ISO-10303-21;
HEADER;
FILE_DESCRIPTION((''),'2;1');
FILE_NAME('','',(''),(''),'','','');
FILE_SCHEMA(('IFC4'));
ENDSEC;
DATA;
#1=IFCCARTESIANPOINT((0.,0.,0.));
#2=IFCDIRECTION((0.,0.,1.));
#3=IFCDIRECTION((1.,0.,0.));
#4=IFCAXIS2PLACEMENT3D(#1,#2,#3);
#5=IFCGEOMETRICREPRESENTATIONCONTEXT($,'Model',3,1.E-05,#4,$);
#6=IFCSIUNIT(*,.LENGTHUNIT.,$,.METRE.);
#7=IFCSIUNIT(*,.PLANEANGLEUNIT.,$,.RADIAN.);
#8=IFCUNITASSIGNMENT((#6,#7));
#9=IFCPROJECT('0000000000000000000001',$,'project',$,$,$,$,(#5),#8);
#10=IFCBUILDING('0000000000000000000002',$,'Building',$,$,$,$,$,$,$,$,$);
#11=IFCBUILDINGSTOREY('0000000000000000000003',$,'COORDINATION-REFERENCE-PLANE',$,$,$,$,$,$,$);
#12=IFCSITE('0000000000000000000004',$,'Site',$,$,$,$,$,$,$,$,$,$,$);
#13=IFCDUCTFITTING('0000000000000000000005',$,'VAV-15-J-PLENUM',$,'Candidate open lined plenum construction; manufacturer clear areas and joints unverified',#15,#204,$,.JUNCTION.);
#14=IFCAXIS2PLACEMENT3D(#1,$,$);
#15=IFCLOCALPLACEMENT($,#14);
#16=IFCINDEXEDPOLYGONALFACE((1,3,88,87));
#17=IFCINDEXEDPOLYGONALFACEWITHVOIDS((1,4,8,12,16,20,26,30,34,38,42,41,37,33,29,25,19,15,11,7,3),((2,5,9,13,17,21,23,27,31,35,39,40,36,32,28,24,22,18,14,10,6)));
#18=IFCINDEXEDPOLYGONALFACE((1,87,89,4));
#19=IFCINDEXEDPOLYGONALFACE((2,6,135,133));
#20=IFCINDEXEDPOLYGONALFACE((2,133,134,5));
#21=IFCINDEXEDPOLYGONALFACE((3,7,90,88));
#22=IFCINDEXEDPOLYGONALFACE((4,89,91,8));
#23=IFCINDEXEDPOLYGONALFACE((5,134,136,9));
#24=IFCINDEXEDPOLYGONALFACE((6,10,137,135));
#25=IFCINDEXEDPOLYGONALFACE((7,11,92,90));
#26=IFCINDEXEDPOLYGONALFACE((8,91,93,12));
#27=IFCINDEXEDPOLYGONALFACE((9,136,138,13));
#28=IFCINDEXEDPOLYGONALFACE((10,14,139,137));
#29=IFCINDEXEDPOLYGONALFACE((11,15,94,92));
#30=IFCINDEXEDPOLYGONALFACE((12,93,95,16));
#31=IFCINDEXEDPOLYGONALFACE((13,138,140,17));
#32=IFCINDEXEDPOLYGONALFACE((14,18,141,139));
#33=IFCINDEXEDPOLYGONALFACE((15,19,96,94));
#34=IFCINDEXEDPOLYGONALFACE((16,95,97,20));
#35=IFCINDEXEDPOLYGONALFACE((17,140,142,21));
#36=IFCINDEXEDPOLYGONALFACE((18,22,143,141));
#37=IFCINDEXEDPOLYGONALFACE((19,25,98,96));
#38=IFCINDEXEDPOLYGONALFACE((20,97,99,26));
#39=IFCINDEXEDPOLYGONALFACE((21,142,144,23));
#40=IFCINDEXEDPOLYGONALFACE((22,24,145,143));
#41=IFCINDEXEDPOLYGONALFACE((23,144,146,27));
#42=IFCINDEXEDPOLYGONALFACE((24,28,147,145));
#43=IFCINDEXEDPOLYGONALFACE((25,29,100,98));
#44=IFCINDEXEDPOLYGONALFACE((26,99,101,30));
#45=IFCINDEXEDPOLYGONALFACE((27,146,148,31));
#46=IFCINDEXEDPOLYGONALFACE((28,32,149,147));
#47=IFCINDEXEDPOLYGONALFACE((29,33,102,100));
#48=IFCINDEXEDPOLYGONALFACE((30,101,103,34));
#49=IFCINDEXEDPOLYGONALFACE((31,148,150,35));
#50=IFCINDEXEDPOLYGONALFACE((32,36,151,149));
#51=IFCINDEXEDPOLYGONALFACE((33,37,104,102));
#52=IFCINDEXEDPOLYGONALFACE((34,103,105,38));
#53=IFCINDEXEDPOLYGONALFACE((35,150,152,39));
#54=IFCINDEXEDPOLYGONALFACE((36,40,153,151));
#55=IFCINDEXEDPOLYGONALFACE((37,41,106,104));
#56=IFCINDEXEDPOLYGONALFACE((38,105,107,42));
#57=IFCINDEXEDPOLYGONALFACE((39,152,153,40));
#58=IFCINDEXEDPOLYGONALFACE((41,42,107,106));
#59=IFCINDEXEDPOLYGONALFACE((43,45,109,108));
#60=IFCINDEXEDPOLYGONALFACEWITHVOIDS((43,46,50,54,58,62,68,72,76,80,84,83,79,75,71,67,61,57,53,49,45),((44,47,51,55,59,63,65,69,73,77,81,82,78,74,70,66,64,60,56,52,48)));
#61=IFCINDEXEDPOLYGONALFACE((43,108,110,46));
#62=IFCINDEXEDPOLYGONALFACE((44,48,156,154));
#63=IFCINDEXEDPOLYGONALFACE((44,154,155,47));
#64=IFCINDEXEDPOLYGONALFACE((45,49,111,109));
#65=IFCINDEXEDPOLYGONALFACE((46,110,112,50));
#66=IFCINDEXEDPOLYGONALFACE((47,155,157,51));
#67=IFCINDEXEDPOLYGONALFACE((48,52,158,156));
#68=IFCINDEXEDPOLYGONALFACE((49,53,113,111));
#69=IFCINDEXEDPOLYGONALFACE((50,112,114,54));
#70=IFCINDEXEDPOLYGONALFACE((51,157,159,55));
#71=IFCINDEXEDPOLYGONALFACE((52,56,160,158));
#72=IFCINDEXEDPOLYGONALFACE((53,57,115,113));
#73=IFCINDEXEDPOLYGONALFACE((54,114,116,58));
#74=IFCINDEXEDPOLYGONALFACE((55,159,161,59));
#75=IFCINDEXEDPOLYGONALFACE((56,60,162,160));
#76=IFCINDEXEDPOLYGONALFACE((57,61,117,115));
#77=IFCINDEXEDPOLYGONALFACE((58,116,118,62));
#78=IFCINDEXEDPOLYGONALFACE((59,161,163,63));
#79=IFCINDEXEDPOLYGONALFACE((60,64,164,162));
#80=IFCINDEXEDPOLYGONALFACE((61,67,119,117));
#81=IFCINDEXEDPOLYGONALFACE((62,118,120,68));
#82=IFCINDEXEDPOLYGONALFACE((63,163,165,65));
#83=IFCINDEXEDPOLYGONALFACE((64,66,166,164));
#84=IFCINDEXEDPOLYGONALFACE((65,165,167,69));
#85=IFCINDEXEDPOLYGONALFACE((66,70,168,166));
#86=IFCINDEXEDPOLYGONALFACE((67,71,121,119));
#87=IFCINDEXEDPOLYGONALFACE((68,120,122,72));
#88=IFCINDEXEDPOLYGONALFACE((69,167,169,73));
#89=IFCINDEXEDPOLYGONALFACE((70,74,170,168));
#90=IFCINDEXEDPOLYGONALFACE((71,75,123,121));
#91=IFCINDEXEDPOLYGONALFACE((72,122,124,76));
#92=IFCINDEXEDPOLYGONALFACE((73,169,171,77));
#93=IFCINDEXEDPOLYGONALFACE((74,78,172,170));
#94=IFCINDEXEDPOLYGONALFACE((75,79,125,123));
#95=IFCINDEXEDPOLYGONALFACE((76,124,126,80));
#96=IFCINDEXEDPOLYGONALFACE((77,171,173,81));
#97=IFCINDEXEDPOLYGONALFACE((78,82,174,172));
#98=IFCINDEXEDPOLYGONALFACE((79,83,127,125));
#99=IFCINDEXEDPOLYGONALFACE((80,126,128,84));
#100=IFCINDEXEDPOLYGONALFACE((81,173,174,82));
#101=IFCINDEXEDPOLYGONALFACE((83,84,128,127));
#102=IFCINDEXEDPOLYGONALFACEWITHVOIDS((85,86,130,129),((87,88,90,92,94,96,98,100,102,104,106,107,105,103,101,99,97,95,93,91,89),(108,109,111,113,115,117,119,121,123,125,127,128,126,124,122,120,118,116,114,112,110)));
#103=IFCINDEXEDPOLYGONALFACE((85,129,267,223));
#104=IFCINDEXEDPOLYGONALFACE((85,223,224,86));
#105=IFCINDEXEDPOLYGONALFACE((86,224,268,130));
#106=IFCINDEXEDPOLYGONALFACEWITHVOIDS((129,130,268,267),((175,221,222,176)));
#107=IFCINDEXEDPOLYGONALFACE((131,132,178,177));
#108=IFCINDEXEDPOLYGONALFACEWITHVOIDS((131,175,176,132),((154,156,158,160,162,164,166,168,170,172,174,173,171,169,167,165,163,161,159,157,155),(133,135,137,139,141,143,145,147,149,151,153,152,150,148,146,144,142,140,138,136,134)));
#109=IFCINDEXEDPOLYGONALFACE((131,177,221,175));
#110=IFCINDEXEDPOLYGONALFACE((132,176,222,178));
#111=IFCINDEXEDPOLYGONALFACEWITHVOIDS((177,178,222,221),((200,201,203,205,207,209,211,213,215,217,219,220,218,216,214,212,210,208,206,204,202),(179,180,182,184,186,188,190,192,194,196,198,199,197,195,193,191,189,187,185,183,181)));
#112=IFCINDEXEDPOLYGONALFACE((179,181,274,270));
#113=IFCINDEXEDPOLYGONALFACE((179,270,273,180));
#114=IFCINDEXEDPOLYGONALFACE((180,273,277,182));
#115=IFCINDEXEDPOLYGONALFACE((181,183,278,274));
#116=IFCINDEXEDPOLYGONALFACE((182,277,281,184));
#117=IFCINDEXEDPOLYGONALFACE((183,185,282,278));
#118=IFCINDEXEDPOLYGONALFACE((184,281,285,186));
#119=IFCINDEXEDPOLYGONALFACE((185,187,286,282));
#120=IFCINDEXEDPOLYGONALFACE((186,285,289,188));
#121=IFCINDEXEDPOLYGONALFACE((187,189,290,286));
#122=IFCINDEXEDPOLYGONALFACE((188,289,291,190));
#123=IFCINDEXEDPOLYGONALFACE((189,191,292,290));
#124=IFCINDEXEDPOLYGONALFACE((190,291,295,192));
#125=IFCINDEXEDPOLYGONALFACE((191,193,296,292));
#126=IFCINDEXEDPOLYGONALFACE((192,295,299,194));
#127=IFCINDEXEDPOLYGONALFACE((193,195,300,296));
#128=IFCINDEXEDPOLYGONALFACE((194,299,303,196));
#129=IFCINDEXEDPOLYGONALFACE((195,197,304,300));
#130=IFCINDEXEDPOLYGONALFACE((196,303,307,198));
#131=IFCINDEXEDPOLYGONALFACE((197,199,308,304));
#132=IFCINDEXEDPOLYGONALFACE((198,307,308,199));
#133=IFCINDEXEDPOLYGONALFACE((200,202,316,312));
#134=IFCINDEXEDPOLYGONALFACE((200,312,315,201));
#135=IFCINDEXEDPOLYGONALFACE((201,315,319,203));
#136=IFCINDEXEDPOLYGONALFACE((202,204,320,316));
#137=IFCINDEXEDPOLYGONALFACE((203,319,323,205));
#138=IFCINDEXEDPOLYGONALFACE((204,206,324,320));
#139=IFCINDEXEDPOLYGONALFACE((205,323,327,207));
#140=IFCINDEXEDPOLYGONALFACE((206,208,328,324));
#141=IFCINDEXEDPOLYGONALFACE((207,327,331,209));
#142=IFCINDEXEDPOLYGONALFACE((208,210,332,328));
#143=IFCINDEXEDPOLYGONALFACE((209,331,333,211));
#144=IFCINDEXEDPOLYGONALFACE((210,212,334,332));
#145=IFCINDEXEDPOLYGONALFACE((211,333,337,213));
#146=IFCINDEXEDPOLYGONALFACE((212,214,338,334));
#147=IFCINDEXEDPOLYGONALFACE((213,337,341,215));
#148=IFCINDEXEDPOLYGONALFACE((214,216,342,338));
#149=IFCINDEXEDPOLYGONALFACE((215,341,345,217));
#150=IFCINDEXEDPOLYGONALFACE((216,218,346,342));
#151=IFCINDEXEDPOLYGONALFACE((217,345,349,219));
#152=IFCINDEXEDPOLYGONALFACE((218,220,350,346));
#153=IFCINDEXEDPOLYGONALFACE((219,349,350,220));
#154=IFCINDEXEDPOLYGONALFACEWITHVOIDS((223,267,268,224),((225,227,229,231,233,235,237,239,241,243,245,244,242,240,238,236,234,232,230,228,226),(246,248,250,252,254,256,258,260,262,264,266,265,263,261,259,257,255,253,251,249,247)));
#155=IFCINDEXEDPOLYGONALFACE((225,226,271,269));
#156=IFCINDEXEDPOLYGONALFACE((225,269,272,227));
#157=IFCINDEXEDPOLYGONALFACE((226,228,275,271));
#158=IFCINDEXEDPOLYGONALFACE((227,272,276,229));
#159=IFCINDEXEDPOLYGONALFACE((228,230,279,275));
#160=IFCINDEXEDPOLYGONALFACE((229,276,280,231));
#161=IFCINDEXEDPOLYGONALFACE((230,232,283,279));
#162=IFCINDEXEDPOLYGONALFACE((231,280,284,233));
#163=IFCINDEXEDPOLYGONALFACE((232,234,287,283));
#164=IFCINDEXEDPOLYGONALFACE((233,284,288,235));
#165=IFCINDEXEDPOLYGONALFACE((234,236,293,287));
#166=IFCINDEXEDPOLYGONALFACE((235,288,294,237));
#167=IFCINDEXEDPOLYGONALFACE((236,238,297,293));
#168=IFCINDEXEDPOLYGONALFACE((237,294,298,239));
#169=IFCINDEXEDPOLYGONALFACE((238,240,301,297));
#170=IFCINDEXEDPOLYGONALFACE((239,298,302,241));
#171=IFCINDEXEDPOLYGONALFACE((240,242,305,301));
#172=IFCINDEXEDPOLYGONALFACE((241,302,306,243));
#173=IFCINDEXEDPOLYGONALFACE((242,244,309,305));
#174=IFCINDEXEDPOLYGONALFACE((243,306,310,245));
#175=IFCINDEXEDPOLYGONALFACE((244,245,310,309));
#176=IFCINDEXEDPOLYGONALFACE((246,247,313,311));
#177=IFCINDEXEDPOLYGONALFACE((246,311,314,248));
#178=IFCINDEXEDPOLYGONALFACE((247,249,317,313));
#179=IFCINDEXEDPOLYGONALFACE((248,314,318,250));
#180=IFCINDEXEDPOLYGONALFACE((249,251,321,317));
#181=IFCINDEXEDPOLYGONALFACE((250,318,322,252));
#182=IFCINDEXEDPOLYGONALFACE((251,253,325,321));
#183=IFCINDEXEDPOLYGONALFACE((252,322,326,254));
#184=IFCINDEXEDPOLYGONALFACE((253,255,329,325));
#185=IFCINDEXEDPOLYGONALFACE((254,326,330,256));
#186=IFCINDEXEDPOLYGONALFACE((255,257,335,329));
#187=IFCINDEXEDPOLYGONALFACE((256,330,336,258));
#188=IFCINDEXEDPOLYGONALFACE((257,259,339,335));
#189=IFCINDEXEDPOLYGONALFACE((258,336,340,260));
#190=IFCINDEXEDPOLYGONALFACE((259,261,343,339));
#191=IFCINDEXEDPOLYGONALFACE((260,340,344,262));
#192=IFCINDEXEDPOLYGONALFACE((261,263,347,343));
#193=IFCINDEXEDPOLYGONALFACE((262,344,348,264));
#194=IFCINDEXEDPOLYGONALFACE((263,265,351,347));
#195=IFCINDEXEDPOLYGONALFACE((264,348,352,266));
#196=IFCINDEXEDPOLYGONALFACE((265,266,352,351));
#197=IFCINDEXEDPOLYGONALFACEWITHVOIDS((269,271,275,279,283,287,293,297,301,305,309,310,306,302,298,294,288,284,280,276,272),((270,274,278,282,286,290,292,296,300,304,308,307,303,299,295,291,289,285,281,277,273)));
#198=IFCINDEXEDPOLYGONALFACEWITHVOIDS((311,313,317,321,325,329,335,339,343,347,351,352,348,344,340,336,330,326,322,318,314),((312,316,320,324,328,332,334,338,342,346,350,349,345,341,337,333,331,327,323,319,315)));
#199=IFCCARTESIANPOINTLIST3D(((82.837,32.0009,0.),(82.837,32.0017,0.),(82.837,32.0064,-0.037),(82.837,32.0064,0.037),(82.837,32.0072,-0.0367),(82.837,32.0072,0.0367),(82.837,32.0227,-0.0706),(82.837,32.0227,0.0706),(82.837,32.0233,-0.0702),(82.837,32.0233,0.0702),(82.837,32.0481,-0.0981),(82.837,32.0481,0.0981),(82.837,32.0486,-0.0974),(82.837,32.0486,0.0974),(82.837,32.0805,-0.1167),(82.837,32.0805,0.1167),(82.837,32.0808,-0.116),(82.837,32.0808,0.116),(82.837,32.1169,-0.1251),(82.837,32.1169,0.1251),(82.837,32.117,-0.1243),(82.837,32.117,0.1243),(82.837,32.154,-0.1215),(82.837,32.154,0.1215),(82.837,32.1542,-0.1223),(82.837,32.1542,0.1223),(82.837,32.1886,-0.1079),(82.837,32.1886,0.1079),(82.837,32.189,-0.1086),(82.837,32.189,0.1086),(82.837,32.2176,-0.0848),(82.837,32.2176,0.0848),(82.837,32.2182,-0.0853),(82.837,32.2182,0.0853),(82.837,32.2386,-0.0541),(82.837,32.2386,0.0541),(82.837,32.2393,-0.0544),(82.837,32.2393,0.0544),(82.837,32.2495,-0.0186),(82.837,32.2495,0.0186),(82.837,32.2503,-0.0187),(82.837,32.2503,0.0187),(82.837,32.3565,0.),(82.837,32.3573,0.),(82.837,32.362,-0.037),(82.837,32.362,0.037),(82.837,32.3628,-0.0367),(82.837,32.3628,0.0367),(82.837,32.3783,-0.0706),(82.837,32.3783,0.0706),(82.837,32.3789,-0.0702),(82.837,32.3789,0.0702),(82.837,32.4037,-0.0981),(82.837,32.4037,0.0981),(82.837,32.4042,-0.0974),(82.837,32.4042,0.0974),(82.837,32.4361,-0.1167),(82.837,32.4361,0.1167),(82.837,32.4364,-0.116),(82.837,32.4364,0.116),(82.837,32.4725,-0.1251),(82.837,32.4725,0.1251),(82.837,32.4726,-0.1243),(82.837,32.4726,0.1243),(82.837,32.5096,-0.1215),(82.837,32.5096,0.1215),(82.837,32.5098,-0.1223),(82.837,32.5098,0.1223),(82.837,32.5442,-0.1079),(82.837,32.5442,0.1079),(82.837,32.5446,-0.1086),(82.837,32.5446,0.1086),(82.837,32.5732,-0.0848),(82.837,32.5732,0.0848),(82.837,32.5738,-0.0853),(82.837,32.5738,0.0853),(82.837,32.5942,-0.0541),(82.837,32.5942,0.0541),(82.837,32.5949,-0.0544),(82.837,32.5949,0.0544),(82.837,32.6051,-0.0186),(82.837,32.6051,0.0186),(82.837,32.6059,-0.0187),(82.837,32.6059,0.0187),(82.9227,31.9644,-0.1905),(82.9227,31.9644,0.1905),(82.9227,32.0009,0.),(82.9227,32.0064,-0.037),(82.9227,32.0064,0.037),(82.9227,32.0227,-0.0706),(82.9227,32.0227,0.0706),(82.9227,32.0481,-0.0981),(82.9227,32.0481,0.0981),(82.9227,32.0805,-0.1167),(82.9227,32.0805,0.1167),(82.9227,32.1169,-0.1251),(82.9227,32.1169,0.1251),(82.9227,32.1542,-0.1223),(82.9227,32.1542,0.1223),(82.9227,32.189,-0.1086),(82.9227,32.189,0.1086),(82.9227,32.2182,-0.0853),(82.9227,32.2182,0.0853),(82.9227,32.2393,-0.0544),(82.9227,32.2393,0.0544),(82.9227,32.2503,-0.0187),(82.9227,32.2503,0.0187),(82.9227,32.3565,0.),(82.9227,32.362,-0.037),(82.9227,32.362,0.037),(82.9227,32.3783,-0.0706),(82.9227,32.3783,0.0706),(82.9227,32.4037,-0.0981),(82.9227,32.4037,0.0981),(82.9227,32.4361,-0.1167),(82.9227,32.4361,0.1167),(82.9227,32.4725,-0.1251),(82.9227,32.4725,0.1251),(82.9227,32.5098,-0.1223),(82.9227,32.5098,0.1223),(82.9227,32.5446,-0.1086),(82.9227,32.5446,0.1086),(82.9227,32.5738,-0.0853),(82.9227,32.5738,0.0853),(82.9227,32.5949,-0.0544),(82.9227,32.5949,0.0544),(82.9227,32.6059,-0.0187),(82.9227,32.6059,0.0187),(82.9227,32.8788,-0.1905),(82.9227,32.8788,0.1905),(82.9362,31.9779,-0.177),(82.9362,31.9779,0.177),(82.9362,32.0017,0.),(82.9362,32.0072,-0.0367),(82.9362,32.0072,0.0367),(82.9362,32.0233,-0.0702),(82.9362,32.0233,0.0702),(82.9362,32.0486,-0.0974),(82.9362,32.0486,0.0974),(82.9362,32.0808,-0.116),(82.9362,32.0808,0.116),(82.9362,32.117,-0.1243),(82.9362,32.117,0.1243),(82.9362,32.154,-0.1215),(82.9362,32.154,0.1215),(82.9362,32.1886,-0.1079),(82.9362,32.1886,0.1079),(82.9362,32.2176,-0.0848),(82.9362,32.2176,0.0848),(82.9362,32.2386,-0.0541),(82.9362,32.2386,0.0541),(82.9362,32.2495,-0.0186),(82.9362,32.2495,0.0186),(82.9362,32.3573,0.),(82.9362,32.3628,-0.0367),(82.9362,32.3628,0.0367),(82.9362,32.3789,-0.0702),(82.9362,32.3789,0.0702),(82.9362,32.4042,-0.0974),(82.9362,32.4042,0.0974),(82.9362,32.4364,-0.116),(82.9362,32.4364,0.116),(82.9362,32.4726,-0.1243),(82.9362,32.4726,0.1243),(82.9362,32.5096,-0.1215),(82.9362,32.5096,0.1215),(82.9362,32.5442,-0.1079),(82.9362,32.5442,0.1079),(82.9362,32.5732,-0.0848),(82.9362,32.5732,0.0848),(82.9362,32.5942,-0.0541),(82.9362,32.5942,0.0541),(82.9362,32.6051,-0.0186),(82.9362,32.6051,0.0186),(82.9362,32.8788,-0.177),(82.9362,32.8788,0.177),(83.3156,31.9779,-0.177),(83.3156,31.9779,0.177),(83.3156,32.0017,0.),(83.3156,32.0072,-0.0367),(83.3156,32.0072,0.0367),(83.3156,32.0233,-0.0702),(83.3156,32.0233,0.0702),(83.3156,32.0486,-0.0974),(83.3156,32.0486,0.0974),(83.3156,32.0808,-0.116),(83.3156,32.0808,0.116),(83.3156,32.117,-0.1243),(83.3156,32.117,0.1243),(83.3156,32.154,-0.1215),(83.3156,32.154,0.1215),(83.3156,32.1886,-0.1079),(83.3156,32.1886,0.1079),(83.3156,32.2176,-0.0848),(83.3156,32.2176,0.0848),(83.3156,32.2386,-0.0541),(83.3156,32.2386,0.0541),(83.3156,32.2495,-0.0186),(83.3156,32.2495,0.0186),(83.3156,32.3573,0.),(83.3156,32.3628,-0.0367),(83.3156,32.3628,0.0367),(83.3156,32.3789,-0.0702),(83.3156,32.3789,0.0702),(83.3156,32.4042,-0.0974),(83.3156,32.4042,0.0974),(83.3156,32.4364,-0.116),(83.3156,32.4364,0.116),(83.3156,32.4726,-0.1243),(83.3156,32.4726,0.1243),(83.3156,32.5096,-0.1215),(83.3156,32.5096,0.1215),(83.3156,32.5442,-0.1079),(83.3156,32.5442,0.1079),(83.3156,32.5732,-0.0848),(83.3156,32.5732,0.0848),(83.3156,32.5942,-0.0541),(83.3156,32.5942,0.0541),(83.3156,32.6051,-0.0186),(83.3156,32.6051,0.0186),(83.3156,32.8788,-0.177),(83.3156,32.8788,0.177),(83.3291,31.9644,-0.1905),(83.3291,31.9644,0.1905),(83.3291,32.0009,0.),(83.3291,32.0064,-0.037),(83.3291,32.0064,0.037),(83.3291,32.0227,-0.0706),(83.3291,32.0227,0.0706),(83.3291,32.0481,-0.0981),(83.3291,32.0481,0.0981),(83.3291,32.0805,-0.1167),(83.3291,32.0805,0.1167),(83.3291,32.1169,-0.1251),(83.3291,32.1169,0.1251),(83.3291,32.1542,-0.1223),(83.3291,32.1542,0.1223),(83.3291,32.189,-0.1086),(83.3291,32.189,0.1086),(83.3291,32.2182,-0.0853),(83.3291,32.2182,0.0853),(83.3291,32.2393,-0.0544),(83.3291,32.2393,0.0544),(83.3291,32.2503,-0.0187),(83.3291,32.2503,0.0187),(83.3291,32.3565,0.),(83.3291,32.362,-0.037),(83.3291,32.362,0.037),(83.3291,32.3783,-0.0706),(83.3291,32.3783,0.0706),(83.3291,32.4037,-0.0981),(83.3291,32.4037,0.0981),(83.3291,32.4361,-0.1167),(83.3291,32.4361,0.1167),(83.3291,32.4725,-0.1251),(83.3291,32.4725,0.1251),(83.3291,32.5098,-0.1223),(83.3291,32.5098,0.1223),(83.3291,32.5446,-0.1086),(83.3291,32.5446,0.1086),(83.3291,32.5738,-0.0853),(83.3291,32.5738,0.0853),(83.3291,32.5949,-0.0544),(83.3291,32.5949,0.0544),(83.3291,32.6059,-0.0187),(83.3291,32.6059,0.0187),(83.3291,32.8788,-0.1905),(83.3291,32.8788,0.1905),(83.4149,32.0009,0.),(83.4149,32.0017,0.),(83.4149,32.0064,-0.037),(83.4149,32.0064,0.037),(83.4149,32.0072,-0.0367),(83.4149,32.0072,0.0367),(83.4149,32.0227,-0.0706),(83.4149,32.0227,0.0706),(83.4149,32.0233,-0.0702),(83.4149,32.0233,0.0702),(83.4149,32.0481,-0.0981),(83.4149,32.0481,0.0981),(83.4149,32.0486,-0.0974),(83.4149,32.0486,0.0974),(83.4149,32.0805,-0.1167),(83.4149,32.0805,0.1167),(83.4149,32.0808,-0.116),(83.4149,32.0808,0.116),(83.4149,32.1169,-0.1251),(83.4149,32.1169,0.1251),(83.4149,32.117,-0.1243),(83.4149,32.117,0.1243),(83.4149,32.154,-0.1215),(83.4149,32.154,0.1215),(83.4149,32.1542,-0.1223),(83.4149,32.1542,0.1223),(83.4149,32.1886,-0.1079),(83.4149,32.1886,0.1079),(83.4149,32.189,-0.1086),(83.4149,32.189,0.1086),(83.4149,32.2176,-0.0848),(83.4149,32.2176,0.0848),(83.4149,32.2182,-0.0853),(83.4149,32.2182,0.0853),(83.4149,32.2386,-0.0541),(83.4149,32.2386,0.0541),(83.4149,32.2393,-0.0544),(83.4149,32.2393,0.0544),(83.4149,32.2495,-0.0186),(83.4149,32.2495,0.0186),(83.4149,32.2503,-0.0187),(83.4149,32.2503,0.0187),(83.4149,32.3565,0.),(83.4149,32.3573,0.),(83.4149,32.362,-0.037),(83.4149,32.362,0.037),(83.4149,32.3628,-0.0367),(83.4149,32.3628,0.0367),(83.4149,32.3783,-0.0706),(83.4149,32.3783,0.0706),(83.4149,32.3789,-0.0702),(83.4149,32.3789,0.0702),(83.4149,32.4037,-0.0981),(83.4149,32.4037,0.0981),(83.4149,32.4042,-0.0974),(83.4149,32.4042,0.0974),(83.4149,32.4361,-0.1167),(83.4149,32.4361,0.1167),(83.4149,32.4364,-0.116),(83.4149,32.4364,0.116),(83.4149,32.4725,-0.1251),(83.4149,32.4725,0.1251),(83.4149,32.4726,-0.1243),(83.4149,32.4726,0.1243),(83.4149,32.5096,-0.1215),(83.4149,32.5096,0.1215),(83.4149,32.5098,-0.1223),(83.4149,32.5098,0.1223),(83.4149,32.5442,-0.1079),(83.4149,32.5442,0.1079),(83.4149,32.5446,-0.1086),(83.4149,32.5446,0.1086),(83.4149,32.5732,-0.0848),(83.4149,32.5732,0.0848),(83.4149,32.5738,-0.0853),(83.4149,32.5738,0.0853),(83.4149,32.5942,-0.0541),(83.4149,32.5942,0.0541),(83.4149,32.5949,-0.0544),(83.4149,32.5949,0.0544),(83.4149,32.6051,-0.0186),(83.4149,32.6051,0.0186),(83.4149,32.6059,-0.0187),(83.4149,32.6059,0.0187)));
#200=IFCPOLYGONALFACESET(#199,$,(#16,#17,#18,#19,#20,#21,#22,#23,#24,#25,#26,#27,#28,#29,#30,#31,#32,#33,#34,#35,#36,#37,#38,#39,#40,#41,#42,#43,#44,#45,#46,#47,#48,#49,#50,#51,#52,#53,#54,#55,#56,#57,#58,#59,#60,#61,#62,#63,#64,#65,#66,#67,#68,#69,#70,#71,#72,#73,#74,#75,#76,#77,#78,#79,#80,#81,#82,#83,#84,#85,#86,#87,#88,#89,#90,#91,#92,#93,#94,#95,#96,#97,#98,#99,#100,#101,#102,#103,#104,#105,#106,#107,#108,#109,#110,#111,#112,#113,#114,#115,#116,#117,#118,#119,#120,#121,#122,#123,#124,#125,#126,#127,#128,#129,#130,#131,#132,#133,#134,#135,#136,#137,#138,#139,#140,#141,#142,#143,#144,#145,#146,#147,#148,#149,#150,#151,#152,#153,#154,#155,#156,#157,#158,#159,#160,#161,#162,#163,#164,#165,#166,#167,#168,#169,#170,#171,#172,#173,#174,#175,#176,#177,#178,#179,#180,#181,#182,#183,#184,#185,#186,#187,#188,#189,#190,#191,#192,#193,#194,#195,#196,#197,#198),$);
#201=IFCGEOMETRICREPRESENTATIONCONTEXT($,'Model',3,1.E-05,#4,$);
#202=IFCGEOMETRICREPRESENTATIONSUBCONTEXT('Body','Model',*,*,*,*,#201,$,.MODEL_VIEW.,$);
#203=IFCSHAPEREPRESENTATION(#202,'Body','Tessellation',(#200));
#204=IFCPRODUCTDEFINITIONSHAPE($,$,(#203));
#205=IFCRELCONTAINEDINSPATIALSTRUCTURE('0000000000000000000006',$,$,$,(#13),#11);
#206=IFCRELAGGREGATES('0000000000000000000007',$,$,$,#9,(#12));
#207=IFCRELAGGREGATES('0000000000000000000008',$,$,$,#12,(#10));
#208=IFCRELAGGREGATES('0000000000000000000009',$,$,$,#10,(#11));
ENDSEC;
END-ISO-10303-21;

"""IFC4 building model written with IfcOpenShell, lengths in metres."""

from ifc_helpers import new_model, si_unit, frame, origin_with_axes, place, context, subcontext, project, spatial, rectangle, circle, extrude, boolean, element, save


model = new_model("IFC4")

# Units and contexts
model_context_1 = context("Model", 3, precision=1e-05, world=origin_with_axes())
model_context_2 = context("Model", 3, precision=1e-05, world=origin_with_axes())
body_context_1 = subcontext(model_context_2, "Body", "Model", "MODEL_VIEW")
ifc_project = project(units=[si_unit("LENGTHUNIT", "METRE"), si_unit("PLANEANGLEUNIT", "RADIAN")], contexts=[model_context_1])

# Site, building, storey
site = spatial("IfcSite", under=ifc_project, Name="Site")
building = spatial("IfcBuilding", under=site, Name="Building")
storey = spatial("IfcBuildingStorey", under=building, Name="COORDINATION-REFERENCE-PLANE")

# Duct fitting
duct_fitting_1_placement = place(None, frame((82.9227, 31.9644, -0.1905), z_axis=(0.0, 0.0, 1.0), x_axis=(1.0, 0.0, 0.0)))
solid_1 = boolean("UNION", boolean("UNION", boolean("UNION", boolean("UNION", extrude(rectangle(XDim=0.3794, YDim=0.354), frame((0.2032, 0.9244, 0.1905), z_axis=(0.0, -1.0, 0.0), x_axis=(1.0, 0.0, 0.0)), (0.0, 0.0, 1.0), 0.9109), extrude(circle(Radius=0.1246), frame((0.0235, 0.5175, 0.1905), z_axis=(-1.0, 0.0, 0.0), x_axis=(0.0, -1.0, 0.0)), (0.0, 0.0, 1.0), 0.1192)), extrude(circle(Radius=0.1246), frame((0.3829, 0.5175, 0.1905), z_axis=(1.0, 0.0, 0.0), x_axis=(0.0, -1.0, 0.0)), (0.0, 0.0, 1.0), 0.1192)), extrude(circle(Radius=0.1246), frame((0.0235, 0.1619, 0.1905), z_axis=(-1.0, 0.0, 0.0), x_axis=(0.0, -1.0, 0.0)), (0.0, 0.0, 1.0), 0.1192)), extrude(circle(Radius=0.1246), frame((0.3829, 0.1619, 0.1905), z_axis=(1.0, 0.0, 0.0), x_axis=(0.0, -1.0, 0.0)), (0.0, 0.0, 1.0), 0.1192))
element("IfcDuctFitting", 1, at=duct_fitting_1_placement, inside=storey, Name="VAV-15-J-PLENUM", ObjectType="Candidate open lined plenum construction; manufacturer clear areas and joints unverified", PredefinedType="JUNCTION", context=body_context_1, shape_type="CSG", body=[
    boolean("DIFFERENCE", boolean("UNION", boolean("UNION", boolean("UNION", boolean("UNION", extrude(rectangle(XDim=0.4064, YDim=0.381), frame((0.2032, 0.9144, 0.1905), z_axis=(0.0, -1.0, 0.0), x_axis=(1.0, 0.0, 0.0)), (0.0, 0.0, 1.0), 0.9144), extrude(circle(Radius=0.1254), frame((0.0235, 0.5175, 0.1905), z_axis=(-1.0, 0.0, 0.0), x_axis=(0.0, -1.0, 0.0)), (0.0, 0.0, 1.0), 0.1092)), extrude(circle(Radius=0.1254), frame((0.3829, 0.5175, 0.1905), z_axis=(1.0, 0.0, 0.0), x_axis=(0.0, -1.0, 0.0)), (0.0, 0.0, 1.0), 0.1092)), extrude(circle(Radius=0.1254), frame((0.0235, 0.1619, 0.1905), z_axis=(-1.0, 0.0, 0.0), x_axis=(0.0, -1.0, 0.0)), (0.0, 0.0, 1.0), 0.1092)), extrude(circle(Radius=0.1254), frame((0.3829, 0.1619, 0.1905), z_axis=(1.0, 0.0, 0.0), x_axis=(0.0, -1.0, 0.0)), (0.0, 0.0, 1.0), 0.1092)), solid_1),
])

save(model, "model.ifc")
